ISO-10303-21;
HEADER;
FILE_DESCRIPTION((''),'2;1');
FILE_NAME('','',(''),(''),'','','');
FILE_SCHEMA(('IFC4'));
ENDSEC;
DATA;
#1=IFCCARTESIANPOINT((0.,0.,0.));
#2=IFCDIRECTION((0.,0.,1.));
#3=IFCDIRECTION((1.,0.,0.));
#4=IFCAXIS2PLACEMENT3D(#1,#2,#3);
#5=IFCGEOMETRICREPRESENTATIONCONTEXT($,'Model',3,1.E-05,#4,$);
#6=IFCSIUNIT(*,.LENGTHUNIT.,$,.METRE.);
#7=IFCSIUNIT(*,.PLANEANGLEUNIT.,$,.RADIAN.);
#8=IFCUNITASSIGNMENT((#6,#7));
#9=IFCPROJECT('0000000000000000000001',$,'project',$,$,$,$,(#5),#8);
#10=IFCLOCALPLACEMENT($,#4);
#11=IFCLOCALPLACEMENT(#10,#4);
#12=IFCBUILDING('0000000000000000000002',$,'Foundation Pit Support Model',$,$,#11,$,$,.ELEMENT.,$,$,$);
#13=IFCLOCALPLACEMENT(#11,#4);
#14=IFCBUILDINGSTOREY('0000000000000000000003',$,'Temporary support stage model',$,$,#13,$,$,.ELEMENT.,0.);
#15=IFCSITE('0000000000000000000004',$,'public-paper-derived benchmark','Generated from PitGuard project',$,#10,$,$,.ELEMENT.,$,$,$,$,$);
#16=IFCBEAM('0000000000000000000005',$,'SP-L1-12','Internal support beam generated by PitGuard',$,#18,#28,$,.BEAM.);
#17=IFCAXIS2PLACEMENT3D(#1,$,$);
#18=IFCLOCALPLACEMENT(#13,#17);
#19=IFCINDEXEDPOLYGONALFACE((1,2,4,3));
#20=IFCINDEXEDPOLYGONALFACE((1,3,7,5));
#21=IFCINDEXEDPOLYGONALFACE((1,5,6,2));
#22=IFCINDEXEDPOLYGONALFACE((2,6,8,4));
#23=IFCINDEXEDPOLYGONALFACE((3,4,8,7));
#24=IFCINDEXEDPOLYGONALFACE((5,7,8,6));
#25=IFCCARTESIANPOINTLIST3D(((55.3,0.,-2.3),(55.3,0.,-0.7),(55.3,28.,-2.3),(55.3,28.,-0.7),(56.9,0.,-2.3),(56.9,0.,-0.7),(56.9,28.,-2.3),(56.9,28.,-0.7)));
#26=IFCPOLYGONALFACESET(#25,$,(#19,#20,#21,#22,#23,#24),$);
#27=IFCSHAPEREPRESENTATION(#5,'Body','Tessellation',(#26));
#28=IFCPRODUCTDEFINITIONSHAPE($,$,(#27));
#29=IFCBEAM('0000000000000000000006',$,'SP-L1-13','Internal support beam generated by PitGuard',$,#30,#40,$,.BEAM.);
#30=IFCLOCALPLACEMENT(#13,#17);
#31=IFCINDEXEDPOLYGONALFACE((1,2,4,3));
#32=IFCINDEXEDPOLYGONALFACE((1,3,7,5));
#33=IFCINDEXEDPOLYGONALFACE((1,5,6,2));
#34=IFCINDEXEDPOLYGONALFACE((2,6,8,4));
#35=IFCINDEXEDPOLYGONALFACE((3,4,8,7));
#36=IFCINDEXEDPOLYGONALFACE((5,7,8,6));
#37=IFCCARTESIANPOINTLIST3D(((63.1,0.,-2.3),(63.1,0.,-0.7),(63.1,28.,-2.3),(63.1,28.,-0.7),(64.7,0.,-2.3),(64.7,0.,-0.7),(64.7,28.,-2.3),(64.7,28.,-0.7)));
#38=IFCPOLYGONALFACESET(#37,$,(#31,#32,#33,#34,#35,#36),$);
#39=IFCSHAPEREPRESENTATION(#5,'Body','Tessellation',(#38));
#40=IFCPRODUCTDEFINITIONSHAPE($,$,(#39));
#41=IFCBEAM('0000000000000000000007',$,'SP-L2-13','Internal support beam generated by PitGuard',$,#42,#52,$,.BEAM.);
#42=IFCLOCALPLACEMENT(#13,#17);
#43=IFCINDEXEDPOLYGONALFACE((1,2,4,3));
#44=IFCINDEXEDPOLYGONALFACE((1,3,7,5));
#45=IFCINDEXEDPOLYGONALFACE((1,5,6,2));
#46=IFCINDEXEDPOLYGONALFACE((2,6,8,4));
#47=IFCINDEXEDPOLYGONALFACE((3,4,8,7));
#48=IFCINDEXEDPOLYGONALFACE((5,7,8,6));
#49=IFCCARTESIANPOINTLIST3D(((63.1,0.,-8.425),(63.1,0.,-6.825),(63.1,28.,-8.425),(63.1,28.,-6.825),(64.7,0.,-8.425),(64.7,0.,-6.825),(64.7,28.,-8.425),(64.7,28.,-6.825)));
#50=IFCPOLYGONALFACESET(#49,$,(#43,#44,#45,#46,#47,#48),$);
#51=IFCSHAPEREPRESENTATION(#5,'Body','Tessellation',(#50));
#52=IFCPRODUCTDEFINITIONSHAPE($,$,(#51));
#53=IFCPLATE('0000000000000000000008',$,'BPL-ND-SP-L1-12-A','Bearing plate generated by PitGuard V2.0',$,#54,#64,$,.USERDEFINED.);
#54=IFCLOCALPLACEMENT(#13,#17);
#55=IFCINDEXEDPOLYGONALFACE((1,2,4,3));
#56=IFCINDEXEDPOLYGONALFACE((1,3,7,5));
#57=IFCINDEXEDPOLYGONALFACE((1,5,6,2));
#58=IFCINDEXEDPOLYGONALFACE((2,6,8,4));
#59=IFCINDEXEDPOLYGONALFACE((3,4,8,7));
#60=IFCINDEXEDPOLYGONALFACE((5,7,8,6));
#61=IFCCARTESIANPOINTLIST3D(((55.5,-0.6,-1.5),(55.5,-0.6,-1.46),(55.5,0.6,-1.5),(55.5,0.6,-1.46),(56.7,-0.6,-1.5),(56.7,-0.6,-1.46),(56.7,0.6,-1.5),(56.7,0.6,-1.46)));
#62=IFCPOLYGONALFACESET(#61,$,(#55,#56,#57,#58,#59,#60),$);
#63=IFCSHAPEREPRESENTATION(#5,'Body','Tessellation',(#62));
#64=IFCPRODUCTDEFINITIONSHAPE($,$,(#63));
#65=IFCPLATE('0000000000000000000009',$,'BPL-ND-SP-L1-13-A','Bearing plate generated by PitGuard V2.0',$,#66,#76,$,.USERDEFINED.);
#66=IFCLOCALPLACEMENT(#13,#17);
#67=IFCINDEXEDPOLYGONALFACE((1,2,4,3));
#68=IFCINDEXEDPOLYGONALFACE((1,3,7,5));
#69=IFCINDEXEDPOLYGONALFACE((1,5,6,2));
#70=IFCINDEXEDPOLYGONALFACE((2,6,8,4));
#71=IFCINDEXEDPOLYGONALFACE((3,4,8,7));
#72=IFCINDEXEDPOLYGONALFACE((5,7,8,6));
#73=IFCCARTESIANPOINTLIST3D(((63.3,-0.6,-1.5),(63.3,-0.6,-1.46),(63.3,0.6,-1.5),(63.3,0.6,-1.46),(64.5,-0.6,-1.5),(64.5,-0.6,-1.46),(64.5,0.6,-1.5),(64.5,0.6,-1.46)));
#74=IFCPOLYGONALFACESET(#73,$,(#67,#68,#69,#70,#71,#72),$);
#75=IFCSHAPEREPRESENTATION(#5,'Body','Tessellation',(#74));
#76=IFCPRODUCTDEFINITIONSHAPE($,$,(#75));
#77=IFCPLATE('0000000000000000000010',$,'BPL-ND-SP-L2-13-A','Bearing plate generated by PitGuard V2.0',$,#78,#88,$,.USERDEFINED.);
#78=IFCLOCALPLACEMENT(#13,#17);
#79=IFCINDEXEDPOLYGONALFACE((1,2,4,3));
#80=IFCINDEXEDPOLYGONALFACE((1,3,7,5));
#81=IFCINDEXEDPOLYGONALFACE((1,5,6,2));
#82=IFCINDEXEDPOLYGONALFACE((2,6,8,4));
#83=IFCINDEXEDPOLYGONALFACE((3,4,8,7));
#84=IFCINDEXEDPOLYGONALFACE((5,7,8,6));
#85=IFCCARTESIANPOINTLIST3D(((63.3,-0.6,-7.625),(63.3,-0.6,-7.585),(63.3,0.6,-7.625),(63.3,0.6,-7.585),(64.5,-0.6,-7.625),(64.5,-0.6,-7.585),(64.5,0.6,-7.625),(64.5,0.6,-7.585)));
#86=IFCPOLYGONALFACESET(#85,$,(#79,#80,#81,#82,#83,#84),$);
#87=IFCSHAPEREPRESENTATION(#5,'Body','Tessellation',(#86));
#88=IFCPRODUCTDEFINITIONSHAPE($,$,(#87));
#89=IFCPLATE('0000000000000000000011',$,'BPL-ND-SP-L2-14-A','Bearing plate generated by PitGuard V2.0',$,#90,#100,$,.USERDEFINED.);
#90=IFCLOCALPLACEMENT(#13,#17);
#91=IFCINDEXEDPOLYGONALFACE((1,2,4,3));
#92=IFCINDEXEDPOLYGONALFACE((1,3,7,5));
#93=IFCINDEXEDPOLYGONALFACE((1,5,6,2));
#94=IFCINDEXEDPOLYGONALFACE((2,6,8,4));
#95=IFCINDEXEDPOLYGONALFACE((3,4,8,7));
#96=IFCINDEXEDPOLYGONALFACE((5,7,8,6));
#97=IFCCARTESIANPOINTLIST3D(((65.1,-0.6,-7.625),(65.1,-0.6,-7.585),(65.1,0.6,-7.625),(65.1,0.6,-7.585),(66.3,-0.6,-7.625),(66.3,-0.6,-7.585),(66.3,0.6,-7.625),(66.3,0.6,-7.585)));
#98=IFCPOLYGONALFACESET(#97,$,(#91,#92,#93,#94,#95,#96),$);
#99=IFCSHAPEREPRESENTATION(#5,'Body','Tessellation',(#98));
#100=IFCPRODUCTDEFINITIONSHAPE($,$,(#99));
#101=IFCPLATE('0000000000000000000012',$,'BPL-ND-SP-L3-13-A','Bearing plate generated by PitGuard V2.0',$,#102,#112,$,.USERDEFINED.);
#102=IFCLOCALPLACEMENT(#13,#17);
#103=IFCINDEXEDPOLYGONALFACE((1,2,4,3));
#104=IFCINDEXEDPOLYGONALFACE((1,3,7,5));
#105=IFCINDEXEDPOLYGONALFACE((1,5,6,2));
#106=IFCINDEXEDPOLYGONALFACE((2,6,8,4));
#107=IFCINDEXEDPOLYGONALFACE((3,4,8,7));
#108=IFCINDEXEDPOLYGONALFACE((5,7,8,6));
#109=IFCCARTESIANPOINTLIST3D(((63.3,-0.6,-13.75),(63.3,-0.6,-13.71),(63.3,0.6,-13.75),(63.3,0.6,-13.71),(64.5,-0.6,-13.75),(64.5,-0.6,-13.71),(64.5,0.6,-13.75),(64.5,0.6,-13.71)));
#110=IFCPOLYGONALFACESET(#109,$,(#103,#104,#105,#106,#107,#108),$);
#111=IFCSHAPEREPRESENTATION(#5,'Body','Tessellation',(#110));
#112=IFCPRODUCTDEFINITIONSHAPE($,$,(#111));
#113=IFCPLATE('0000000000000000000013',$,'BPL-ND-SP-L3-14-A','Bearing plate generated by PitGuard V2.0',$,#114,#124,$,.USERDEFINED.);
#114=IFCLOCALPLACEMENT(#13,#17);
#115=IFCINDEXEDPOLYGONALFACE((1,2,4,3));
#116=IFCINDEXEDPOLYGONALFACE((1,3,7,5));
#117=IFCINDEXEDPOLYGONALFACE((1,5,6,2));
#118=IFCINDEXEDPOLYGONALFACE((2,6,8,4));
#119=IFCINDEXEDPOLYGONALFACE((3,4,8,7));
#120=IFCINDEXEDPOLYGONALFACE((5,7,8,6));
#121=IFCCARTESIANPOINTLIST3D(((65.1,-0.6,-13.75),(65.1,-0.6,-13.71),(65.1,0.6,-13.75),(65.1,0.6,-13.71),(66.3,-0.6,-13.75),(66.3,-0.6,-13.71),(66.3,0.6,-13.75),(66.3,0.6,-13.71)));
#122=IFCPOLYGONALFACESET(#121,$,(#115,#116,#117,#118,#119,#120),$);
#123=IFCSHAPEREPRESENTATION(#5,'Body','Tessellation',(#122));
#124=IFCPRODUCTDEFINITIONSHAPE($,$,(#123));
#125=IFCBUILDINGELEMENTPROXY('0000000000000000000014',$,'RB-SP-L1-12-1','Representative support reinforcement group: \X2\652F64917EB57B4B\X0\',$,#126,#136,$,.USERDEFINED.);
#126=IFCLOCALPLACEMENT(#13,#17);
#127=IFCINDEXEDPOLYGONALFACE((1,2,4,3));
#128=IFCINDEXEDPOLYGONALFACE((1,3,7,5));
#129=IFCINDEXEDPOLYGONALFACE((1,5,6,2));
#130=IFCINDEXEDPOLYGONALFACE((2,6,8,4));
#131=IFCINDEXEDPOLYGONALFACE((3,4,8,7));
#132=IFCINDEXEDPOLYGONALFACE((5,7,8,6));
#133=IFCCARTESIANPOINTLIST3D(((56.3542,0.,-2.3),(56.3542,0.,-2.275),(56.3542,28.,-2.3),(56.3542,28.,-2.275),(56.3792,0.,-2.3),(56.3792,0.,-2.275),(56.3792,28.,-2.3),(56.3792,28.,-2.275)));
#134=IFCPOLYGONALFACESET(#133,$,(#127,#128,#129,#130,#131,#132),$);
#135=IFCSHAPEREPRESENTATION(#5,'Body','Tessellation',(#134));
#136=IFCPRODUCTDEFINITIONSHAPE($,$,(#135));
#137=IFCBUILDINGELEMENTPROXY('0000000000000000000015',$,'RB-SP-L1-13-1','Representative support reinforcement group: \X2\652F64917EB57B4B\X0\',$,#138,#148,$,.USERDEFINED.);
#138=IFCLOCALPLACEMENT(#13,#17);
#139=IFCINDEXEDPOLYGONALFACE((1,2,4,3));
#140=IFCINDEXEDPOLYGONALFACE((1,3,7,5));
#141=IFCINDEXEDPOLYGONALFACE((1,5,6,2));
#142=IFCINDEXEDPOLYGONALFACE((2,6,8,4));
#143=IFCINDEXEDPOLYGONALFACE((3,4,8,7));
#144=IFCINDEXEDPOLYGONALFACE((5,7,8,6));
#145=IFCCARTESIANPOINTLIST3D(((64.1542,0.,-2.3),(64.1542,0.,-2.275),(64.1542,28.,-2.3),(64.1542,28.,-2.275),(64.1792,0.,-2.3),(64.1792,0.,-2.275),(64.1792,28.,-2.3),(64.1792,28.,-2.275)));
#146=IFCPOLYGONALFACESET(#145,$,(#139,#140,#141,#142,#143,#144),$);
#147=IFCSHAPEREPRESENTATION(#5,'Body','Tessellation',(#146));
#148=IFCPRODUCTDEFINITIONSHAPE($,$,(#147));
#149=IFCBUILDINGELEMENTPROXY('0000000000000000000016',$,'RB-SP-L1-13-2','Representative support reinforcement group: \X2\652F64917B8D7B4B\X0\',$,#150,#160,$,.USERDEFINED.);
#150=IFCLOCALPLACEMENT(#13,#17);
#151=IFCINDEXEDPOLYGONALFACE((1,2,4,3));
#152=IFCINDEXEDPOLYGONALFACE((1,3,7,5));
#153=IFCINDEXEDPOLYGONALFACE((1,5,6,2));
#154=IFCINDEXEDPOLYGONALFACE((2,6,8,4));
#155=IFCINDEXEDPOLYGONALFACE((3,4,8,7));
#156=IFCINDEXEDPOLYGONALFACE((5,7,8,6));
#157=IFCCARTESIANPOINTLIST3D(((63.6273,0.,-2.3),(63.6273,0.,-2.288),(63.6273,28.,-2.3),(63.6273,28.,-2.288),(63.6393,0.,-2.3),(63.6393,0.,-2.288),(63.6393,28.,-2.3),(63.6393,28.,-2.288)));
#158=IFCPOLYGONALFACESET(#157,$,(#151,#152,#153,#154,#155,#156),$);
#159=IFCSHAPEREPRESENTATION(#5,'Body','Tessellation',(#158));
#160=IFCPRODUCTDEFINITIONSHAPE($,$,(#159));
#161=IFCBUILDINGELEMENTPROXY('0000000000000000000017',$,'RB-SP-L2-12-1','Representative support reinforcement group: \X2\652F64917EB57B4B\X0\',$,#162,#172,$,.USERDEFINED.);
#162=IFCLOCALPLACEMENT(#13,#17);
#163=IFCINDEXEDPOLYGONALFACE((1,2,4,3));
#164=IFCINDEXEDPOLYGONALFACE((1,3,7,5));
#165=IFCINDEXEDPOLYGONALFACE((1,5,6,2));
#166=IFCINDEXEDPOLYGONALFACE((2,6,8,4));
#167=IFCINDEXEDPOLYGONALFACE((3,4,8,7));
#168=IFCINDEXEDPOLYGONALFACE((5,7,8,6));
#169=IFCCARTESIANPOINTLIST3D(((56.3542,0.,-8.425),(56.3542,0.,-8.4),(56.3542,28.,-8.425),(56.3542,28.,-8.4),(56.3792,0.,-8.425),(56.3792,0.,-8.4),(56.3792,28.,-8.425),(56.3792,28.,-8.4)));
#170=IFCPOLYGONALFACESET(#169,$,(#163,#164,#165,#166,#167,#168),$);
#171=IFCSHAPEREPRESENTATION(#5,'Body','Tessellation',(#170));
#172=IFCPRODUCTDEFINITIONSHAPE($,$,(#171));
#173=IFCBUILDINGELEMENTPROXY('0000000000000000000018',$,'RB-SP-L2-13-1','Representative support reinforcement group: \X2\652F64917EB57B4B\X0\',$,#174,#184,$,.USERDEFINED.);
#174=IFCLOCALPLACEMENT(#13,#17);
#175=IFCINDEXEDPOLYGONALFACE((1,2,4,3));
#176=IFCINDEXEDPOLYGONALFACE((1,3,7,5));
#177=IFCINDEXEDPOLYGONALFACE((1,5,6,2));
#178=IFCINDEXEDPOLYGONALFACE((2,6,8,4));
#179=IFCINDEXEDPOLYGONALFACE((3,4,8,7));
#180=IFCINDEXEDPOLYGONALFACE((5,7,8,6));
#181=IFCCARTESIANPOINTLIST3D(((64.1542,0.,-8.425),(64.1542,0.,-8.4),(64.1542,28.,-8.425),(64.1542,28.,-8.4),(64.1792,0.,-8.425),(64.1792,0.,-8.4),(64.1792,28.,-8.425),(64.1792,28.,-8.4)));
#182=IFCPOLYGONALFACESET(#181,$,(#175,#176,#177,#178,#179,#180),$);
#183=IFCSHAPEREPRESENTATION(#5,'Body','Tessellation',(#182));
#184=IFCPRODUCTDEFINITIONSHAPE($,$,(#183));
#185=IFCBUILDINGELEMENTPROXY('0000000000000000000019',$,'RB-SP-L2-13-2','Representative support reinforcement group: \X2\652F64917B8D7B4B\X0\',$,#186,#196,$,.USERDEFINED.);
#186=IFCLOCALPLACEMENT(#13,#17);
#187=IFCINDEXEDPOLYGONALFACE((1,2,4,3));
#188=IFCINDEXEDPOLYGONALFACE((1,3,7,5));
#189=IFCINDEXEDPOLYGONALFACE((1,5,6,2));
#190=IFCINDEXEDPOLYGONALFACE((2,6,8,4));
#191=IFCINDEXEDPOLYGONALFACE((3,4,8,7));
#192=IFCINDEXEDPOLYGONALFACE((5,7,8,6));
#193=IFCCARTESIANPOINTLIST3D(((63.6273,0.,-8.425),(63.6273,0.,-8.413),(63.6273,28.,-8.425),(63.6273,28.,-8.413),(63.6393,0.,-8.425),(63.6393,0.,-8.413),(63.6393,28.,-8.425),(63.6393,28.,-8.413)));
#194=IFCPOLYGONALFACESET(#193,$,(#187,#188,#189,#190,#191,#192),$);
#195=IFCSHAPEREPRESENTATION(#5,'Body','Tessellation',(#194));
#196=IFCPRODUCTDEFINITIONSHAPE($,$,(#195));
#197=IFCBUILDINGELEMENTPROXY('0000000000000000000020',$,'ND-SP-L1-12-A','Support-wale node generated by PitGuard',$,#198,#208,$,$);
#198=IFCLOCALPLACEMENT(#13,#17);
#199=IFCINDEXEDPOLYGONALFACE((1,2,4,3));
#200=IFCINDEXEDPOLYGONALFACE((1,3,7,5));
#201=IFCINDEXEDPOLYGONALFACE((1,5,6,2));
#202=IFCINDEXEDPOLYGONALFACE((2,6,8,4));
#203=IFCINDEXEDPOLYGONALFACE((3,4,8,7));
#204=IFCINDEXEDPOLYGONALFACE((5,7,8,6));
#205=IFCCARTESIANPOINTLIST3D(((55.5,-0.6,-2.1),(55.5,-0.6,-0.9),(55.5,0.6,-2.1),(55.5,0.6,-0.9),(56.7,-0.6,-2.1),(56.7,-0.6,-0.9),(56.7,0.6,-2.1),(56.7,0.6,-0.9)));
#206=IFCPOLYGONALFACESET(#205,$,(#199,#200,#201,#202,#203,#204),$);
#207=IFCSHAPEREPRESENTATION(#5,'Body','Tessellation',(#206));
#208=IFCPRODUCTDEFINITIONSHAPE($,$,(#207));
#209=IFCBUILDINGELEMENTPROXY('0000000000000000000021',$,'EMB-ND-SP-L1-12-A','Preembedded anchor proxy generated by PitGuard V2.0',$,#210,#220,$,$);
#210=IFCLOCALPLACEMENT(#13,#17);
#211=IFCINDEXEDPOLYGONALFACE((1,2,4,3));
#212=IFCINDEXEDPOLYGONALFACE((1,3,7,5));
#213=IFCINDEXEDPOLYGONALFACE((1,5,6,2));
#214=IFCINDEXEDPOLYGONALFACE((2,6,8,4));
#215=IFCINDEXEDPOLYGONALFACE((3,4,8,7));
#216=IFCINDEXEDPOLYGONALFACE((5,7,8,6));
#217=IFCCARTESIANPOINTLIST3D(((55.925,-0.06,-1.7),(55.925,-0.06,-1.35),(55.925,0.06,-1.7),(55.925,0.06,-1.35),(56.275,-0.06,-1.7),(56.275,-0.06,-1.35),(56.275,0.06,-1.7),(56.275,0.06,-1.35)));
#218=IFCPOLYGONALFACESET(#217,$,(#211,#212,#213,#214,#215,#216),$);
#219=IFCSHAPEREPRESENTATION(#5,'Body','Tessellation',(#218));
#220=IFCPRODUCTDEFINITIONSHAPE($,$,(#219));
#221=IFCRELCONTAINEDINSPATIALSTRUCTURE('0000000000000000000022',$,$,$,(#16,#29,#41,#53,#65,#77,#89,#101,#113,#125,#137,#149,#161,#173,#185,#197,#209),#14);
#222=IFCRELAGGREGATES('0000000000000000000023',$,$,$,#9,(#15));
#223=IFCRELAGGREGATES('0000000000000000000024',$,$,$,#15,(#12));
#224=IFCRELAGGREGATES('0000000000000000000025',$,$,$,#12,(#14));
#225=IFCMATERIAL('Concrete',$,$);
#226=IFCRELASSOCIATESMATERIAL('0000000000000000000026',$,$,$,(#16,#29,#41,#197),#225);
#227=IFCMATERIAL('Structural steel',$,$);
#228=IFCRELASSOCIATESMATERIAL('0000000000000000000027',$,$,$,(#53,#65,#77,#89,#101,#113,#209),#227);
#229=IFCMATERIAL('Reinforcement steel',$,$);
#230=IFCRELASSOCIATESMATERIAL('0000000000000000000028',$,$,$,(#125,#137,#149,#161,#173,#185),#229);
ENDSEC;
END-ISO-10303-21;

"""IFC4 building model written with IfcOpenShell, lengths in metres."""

from ifc_helpers import new_model, si_unit, frame, origin_with_axes, origin_2d, place, context, project, spatial, rectangle, extrude, material, element, save


model = new_model("IFC4")

# Units and contexts
model_context = context("Model", 3, precision=1e-05, world=origin_with_axes())
ifc_project = project(units=[si_unit("LENGTHUNIT", "METRE"), si_unit("PLANEANGLEUNIT", "RADIAN")], contexts=[model_context])

# Site, building, storey
site_placement = place(None, origin_with_axes())
site = spatial("IfcSite", under=ifc_project, at=site_placement, Name="public-paper-derived benchmark", Description="Generated from PitGuard project", CompositionType="ELEMENT")
building_placement = place(site_placement, origin_with_axes())
building = spatial("IfcBuilding", under=site, at=building_placement, Name="Foundation Pit Support Model", CompositionType="ELEMENT")
storey_placement = place(building_placement, origin_with_axes())
storey = spatial("IfcBuildingStorey", under=building, at=storey_placement, Name="Temporary support stage model", CompositionType="ELEMENT", Elevation=0.0)

# Beams
ifc_material_1 = material(Name="Concrete")
for number, where, z_axis, x_axis, name in (
    (1, (56.1, 14.0, -2.3), (0.0, 0.0, 1.0), (0.0, 1.0, 0.0), "SP-L1-12"),
    (2, (63.9, 14.0, -2.3), (0.0, 0.0, 1.0), (0.0, 1.0, 0.0), "SP-L1-13"),
    (3, (63.9, 14.0, -8.425), (0.0, 0.0, 1.0), (0.0, 1.0, 0.0), "SP-L2-13"),
):
    element("IfcBeam", number, at=place(storey_placement, frame(where, z_axis=z_axis, x_axis=x_axis)), inside=storey, material=ifc_material_1, Name=name, Description="Internal support beam generated by PitGuard", PredefinedType="BEAM", context=model_context, shape_type="SweptSolid", body=[
        extrude(rectangle(XDim=28.0, YDim=1.6, at=origin_2d()), origin_with_axes(), (0.0, 0.0, 1.0), 1.6),
    ])

# Plates
ifc_material_2 = material(Name="Structural steel")
for number, where, z_axis, x_axis, name in (
    (4, (56.1, 0.0, -1.5), (0.0, 0.0, 1.0), (1.0, 0.0, 0.0), "BPL-ND-SP-L1-12-A"),
    (5, (63.9, 0.0, -1.5), (0.0, 0.0, 1.0), (1.0, 0.0, 0.0), "BPL-ND-SP-L1-13-A"),
    (6, (63.9, 0.0, -7.625), (0.0, 0.0, 1.0), (1.0, 0.0, 0.0), "BPL-ND-SP-L2-13-A"),
    (7, (65.7, 0.0, -7.625), (0.0, 0.0, 1.0), (1.0, 0.0, 0.0), "BPL-ND-SP-L2-14-A"),
    (8, (63.9, 0.0, -13.75), (0.0, 0.0, 1.0), (1.0, 0.0, 0.0), "BPL-ND-SP-L3-13-A"),
    (9, (65.7, 0.0, -13.75), (0.0, 0.0, 1.0), (1.0, 0.0, 0.0), "BPL-ND-SP-L3-14-A"),
):
    element("IfcPlate", number, at=place(storey_placement, frame(where, z_axis=z_axis, x_axis=x_axis)), inside=storey, material=ifc_material_2, Name=name, Description="Bearing plate generated by PitGuard V2.0", PredefinedType="USERDEFINED", context=model_context, shape_type="SweptSolid", body=[
        extrude(rectangle(XDim=1.2, YDim=1.2, at=origin_2d()), origin_with_axes(), (0.0, 0.0, 1.0), 0.04),
    ])

# Building element proxies
ifc_material_3 = material(Name="Reinforcement steel")
for number, where, z_axis, x_axis, name in (
    (10, (56.3667, 14.0, -2.3), (0.0, 0.0, 1.0), (0.0, 1.0, 0.0), "RB-SP-L1-12-1"),
    (11, (64.1667, 14.0, -2.3), (0.0, 0.0, 1.0), (0.0, 1.0, 0.0), "RB-SP-L1-13-1"),
):
    element("IfcBuildingElementProxy", number, at=place(storey_placement, frame(where, z_axis=z_axis, x_axis=x_axis)), inside=storey, material=ifc_material_3, Name=name, Description="Representative support reinforcement group: 支撑纵筋", PredefinedType="USERDEFINED", context=model_context, shape_type="SweptSolid", body=[
        extrude(rectangle(XDim=28.0, YDim=0.025, at=origin_2d()), origin_with_axes(), (0.0, 0.0, 1.0), 0.025),
    ])
proxy_1_placement = place(storey_placement, frame((63.6333, 14.0, -2.3), z_axis=(0.0, 0.0, 1.0), x_axis=(0.0, 1.0, 0.0)))
element("IfcBuildingElementProxy", 12, at=proxy_1_placement, inside=storey, material=ifc_material_3, Name="RB-SP-L1-13-2", Description="Representative support reinforcement group: 支撑箍筋", PredefinedType="USERDEFINED", context=model_context, shape_type="SweptSolid", body=[
    extrude(rectangle(XDim=28.0, YDim=0.012, at=origin_2d()), origin_with_axes(), (0.0, 0.0, 1.0), 0.012),
])
for number, where, z_axis, x_axis, name in (
    (13, (56.3667, 14.0, -8.425), (0.0, 0.0, 1.0), (0.0, 1.0, 0.0), "RB-SP-L2-12-1"),
    (14, (64.1667, 14.0, -8.425), (0.0, 0.0, 1.0), (0.0, 1.0, 0.0), "RB-SP-L2-13-1"),
):
    element("IfcBuildingElementProxy", number, at=place(storey_placement, frame(where, z_axis=z_axis, x_axis=x_axis)), inside=storey, material=ifc_material_3, Name=name, Description="Representative support reinforcement group: 支撑纵筋", PredefinedType="USERDEFINED", context=model_context, shape_type="SweptSolid", body=[
        extrude(rectangle(XDim=28.0, YDim=0.025, at=origin_2d()), origin_with_axes(), (0.0, 0.0, 1.0), 0.025),
    ])
proxy_2_placement = place(storey_placement, frame((63.6333, 14.0, -8.425), z_axis=(0.0, 0.0, 1.0), x_axis=(0.0, 1.0, 0.0)))
element("IfcBuildingElementProxy", 15, at=proxy_2_placement, inside=storey, material=ifc_material_3, Name="RB-SP-L2-13-2", Description="Representative support reinforcement group: 支撑箍筋", PredefinedType="USERDEFINED", context=model_context, shape_type="SweptSolid", body=[
    extrude(rectangle(XDim=28.0, YDim=0.012, at=origin_2d()), origin_with_axes(), (0.0, 0.0, 1.0), 0.012),
])
proxy_3_placement = place(storey_placement, frame((56.1, 0.0, -2.1), z_axis=(0.0, 0.0, 1.0), x_axis=(1.0, 0.0, 0.0)))
element("IfcBuildingElementProxy", 16, at=proxy_3_placement, inside=storey, material=ifc_material_1, Name="ND-SP-L1-12-A", Description="Support-wale node generated by PitGuard", context=model_context, shape_type="SweptSolid", body=[
    extrude(rectangle(XDim=1.2, YDim=1.2, at=origin_2d()), origin_with_axes(), (0.0, 0.0, 1.0), 1.2),
])
proxy_4_placement = place(storey_placement, frame((56.1, 0.0, -1.7), z_axis=(0.0, 0.0, 1.0), x_axis=(1.0, 0.0, 0.0)))
element("IfcBuildingElementProxy", 17, at=proxy_4_placement, inside=storey, material=ifc_material_2, Name="EMB-ND-SP-L1-12-A", Description="Preembedded anchor proxy generated by PitGuard V2.0", context=model_context, shape_type="SweptSolid", body=[
    extrude(rectangle(XDim=0.35, YDim=0.12, at=origin_2d()), origin_with_axes(), (0.0, 0.0, 1.0), 0.35),
])

save(model, "model.ifc")
